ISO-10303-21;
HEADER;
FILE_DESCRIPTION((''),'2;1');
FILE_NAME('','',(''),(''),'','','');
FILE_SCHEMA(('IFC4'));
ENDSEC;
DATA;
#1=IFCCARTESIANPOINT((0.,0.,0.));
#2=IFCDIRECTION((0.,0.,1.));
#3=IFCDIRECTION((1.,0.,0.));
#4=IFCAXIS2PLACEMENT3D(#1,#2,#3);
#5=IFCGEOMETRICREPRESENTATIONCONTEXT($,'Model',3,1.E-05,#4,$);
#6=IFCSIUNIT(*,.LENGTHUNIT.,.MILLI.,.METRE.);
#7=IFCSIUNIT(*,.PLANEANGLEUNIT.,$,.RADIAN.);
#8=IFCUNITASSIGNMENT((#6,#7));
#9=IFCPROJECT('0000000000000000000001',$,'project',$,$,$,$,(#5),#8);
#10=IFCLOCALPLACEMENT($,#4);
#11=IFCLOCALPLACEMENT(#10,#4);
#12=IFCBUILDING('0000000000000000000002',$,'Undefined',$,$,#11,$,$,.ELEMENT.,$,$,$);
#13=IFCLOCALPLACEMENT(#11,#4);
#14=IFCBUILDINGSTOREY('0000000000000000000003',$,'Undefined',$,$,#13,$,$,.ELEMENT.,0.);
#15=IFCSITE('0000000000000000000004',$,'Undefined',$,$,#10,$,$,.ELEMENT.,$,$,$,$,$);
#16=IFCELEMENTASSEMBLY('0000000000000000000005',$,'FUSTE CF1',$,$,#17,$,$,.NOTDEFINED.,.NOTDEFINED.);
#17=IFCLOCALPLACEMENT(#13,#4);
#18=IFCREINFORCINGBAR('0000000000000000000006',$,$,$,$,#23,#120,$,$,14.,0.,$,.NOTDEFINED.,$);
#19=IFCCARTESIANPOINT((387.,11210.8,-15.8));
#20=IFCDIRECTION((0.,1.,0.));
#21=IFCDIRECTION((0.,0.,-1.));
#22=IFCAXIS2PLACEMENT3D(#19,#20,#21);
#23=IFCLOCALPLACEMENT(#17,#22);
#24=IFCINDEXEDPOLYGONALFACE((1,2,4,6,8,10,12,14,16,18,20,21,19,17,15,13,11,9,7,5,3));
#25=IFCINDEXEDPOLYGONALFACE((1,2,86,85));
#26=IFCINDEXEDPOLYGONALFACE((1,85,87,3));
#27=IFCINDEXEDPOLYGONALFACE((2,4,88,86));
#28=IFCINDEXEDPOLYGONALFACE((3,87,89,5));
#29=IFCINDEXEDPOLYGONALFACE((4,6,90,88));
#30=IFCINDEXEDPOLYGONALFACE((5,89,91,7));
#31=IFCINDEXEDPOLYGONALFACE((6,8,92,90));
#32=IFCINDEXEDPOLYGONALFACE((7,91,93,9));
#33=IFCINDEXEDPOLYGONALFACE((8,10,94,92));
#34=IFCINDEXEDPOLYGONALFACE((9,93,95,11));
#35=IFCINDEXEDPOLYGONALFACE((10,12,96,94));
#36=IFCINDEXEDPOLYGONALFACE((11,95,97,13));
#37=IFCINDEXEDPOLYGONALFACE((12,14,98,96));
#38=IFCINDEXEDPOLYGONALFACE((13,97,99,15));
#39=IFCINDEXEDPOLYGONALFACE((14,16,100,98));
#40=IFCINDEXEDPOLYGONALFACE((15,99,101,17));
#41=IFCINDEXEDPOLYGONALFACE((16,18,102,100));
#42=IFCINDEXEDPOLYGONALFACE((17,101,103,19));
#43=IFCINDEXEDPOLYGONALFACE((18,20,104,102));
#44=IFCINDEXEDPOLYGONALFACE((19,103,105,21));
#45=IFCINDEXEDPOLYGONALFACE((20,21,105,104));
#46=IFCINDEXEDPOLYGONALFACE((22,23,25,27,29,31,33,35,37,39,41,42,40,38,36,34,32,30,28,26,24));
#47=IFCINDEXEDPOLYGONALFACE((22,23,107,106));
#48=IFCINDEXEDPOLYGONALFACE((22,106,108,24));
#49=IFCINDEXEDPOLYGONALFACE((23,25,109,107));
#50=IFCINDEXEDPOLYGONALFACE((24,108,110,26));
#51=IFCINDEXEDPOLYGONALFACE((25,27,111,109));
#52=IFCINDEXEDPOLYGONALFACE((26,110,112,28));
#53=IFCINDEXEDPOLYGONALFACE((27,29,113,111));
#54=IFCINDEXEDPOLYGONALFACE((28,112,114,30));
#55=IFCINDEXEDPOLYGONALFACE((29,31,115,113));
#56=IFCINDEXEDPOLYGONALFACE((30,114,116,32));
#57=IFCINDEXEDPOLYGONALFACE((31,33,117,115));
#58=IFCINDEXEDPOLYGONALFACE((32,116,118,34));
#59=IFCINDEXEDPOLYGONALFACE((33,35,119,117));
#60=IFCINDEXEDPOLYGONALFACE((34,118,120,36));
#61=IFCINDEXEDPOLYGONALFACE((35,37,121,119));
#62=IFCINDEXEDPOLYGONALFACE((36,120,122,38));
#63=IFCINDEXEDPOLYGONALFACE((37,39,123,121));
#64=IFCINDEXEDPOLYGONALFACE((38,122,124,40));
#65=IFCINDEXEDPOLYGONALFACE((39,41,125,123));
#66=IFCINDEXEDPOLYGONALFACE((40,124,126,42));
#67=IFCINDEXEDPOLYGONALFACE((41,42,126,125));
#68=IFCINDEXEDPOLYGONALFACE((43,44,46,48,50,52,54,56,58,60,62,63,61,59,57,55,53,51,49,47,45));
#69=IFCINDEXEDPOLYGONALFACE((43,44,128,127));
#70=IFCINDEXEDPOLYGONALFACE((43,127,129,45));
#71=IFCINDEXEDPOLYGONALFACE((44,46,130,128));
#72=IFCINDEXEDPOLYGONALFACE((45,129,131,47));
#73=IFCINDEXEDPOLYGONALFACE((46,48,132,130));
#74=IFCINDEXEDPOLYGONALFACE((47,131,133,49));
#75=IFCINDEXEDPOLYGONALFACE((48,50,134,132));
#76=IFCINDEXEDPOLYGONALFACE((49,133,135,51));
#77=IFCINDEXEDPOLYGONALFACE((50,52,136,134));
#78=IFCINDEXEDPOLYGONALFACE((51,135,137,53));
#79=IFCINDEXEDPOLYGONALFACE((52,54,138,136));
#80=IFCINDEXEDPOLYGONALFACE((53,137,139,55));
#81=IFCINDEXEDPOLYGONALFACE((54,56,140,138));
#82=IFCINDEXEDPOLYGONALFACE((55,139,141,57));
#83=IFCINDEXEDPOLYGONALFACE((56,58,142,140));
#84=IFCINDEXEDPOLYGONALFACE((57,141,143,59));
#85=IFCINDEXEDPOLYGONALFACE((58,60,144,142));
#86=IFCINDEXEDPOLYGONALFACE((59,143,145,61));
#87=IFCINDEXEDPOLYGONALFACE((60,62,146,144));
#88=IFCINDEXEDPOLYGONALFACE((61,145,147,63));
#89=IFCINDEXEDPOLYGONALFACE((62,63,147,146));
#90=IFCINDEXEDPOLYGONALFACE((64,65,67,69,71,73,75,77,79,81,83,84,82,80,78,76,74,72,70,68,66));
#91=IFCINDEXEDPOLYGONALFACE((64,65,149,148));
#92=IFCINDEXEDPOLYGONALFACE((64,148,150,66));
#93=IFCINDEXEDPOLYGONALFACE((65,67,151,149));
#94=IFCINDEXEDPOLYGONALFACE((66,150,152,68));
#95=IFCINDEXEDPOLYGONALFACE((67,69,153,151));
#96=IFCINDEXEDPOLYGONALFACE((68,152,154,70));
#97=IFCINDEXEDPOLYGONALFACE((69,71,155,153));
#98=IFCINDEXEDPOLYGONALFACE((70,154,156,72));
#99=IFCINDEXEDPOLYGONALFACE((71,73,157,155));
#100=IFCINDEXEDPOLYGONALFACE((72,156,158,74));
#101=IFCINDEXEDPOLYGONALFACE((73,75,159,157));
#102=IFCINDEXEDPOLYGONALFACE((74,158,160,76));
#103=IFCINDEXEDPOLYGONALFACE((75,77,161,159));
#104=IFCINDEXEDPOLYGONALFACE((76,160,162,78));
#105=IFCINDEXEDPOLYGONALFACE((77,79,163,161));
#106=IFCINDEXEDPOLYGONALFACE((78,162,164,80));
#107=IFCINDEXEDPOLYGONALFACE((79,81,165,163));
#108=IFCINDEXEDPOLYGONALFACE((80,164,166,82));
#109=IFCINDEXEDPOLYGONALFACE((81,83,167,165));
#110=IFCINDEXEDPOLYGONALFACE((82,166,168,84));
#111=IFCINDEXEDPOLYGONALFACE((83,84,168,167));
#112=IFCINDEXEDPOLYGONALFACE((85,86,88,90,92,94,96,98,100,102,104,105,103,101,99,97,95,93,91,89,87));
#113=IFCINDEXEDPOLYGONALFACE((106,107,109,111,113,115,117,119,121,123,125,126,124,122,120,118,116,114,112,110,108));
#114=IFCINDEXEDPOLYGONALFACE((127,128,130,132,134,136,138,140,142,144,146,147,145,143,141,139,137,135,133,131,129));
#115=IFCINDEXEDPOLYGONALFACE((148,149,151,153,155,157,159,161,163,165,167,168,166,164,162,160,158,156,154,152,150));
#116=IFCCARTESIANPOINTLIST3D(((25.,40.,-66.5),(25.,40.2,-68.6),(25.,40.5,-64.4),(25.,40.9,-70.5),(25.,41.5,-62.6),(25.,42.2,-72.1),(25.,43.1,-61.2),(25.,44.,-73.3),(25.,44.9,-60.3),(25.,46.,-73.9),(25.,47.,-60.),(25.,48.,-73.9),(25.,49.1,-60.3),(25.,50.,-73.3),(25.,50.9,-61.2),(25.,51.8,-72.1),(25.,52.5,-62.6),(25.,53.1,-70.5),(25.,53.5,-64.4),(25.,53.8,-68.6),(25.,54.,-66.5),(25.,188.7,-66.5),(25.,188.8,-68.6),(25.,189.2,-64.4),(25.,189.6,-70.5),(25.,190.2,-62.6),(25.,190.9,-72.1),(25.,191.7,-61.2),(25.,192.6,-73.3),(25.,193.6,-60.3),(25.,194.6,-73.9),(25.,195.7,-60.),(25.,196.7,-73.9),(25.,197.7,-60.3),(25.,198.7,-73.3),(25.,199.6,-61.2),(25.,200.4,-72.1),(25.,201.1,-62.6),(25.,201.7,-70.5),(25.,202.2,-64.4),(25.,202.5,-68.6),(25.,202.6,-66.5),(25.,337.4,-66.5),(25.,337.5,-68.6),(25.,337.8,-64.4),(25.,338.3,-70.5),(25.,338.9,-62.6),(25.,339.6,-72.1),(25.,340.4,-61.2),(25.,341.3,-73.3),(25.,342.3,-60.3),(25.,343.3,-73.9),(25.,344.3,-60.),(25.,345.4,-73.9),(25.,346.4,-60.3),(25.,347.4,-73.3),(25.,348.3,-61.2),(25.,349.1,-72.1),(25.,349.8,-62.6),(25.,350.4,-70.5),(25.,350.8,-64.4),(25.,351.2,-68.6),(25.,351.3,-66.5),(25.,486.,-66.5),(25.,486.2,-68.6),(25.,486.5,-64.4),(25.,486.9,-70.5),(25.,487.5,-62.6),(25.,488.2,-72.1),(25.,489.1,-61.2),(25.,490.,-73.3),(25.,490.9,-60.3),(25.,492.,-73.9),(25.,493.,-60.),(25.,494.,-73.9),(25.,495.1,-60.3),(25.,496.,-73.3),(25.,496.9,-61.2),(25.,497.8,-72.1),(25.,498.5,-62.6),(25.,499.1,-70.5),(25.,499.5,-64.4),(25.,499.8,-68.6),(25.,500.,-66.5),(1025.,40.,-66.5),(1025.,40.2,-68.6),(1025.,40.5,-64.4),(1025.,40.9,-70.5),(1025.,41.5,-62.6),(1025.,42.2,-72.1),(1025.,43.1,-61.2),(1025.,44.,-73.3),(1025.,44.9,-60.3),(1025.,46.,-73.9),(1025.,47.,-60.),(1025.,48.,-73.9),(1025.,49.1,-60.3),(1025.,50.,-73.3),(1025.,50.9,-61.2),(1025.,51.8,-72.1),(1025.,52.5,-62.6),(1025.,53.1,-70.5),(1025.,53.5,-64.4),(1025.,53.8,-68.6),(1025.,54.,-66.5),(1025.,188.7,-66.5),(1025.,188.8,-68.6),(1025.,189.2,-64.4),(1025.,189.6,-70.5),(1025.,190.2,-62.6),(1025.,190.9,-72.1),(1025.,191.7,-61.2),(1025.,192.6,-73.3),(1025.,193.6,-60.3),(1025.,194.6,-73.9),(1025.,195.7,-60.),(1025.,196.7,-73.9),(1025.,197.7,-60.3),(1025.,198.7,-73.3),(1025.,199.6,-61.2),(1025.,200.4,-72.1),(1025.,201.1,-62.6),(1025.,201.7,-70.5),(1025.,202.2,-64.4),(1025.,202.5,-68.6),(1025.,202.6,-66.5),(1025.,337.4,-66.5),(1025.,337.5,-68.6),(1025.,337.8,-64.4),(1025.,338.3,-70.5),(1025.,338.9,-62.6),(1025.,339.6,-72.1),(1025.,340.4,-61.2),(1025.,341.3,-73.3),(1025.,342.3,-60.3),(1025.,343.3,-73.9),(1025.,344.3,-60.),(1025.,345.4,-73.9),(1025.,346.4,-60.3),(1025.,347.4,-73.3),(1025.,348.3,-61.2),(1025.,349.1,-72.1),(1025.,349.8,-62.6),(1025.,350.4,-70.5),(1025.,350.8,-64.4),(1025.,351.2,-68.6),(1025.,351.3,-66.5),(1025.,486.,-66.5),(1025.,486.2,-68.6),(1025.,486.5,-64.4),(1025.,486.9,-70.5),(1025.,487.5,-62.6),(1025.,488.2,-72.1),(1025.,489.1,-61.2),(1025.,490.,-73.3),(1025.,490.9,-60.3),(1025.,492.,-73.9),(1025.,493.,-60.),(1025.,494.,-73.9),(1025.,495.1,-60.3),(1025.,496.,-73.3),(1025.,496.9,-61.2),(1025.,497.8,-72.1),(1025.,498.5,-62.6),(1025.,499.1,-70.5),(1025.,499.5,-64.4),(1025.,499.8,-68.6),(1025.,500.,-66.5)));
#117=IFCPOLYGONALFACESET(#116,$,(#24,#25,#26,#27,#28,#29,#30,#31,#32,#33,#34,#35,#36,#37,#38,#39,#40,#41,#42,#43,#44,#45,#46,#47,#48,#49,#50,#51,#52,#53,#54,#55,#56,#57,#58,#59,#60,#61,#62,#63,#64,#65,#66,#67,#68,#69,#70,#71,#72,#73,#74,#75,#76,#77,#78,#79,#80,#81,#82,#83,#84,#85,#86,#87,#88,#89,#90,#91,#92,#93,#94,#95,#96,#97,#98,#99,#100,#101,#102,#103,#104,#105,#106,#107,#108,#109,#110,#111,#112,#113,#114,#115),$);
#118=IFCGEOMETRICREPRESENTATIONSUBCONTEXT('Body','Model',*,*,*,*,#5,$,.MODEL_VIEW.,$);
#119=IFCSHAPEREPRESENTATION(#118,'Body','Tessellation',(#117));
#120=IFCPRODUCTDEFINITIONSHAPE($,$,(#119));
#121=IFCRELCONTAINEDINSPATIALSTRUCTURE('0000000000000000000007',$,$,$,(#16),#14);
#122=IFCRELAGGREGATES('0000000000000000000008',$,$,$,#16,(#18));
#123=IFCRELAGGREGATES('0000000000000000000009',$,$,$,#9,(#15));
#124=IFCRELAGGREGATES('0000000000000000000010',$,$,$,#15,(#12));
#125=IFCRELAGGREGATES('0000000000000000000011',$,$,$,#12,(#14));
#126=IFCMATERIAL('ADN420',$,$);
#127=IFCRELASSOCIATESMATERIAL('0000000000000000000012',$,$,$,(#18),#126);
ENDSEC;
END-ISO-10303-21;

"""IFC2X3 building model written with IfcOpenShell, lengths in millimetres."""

from ifc_helpers import new_model, entity, si_unit, frame, origin_with_axes, place, context, subcontext, project, spatial, source, transform, mapped, material, element, aggregate, save


model = new_model("IFC2X3")

# Units and contexts
model_context = context("Model", 3, precision=1e-05, world=origin_with_axes())
body_context = subcontext(model_context, "Body", "Model", "MODEL_VIEW")
ifc_project = project(units=[si_unit("LENGTHUNIT", "METRE", prefix="MILLI"), si_unit("PLANEANGLEUNIT", "RADIAN")], contexts=[model_context])

# Site, building, storey
site_placement = place(None, origin_with_axes())
site = spatial("IfcSite", under=ifc_project, at=site_placement, Name="Undefined", CompositionType="ELEMENT")
building_placement = place(site_placement, origin_with_axes())
building = spatial("IfcBuilding", under=site, at=building_placement, Name="Undefined", CompositionType="ELEMENT")
storey_placement = place(building_placement, origin_with_axes())
storey = spatial("IfcBuildingStorey", under=building, at=storey_placement, Name="Undefined", CompositionType="ELEMENT", Elevation=0.0)

# Shared definitions
ifc_material_1 = material(Name="ADN420")

# Element assembly, reinforcing bar
assembly_1_placement = place(storey_placement, origin_with_axes())
assembly_1 = element("IfcElementAssembly", 1, at=assembly_1_placement, inside=storey, Name="FUSTE CF1", AssemblyPlace="NOTDEFINED", PredefinedType="NOTDEFINED")
shared_shape_1 = source(origin_with_axes(), body_context, "Body", "AdvancedSweptSolid", [
    entity("IfcSweptDiskSolid", entity("IfcTrimmedCurve", entity("IfcLine", entity("IfcCartesianPoint", [0.0, 0.0, 0.0]), entity("IfcVector", entity("IfcDirection", [1.0, 0.0, 0.0]), 1.0)), [entity("IfcParameterValue", 0.0)], [entity("IfcParameterValue", 1000.0)], True, "PARAMETER"), 7.0, None, 0.0, 1000.0),
])
shared_shape_2 = source(origin_with_axes(), body_context, "Body", "AdvancedSweptSolid", [
    entity("IfcSweptDiskSolid", entity("IfcTrimmedCurve", entity("IfcLine", entity("IfcCartesianPoint", [0.0, 0.0, 0.0]), entity("IfcVector", entity("IfcDirection", [1.0, 0.0, 0.0]), 1.0)), [entity("IfcParameterValue", 0.0)], [entity("IfcParameterValue", 1000.0)], True, "PARAMETER"), 7.0, None, 0.0, 1000.0),
])
shared_shape_3 = source(origin_with_axes(), body_context, "Body", "AdvancedSweptSolid", [
    entity("IfcSweptDiskSolid", entity("IfcTrimmedCurve", entity("IfcLine", entity("IfcCartesianPoint", [0.0, 0.0, 0.0]), entity("IfcVector", entity("IfcDirection", [1.0, 0.0, 0.0]), 1.0)), [entity("IfcParameterValue", 0.0)], [entity("IfcParameterValue", 1000.0)], True, "PARAMETER"), 7.0, None, 0.0, 1000.0),
])
shared_shape_4 = source(origin_with_axes(), body_context, "Body", "AdvancedSweptSolid", [
    entity("IfcSweptDiskSolid", entity("IfcTrimmedCurve", entity("IfcLine", entity("IfcCartesianPoint", [0.0, 0.0, 0.0]), entity("IfcVector", entity("IfcDirection", [1.0, 0.0, 0.0]), 1.0)), [entity("IfcParameterValue", 0.0)], [entity("IfcParameterValue", 1000.0)], True, "PARAMETER"), 7.0, None, 0.0, 1000.0),
])
reinforcing_bar_1_placement = place(assembly_1_placement, frame((387.0, 11210.8, -15.8), z_axis=(0.0, 1.0, 0.0), x_axis=(0.0, 0.0, -1.0)))
reinforcing_bar_1 = element("IfcReinforcingBar", 2, at=reinforcing_bar_1_placement, material=ifc_material_1, BarRole="NOTDEFINED", CrossSectionArea=0.0, NominalDiameter=14.0, context=body_context, shape_type="MappedRepresentation", body=[
    mapped(shared_shape_1, transform((25.0, 47.0, -67.0))),
    mapped(shared_shape_2, transform((25.0, 195.7, -67.0))),
    mapped(shared_shape_3, transform((25.0, 344.3, -67.0))),
    mapped(shared_shape_4, transform((25.0, 493.0, -67.0))),
])
aggregate(assembly_1, [reinforcing_bar_1])

save(model, "model.ifc")
